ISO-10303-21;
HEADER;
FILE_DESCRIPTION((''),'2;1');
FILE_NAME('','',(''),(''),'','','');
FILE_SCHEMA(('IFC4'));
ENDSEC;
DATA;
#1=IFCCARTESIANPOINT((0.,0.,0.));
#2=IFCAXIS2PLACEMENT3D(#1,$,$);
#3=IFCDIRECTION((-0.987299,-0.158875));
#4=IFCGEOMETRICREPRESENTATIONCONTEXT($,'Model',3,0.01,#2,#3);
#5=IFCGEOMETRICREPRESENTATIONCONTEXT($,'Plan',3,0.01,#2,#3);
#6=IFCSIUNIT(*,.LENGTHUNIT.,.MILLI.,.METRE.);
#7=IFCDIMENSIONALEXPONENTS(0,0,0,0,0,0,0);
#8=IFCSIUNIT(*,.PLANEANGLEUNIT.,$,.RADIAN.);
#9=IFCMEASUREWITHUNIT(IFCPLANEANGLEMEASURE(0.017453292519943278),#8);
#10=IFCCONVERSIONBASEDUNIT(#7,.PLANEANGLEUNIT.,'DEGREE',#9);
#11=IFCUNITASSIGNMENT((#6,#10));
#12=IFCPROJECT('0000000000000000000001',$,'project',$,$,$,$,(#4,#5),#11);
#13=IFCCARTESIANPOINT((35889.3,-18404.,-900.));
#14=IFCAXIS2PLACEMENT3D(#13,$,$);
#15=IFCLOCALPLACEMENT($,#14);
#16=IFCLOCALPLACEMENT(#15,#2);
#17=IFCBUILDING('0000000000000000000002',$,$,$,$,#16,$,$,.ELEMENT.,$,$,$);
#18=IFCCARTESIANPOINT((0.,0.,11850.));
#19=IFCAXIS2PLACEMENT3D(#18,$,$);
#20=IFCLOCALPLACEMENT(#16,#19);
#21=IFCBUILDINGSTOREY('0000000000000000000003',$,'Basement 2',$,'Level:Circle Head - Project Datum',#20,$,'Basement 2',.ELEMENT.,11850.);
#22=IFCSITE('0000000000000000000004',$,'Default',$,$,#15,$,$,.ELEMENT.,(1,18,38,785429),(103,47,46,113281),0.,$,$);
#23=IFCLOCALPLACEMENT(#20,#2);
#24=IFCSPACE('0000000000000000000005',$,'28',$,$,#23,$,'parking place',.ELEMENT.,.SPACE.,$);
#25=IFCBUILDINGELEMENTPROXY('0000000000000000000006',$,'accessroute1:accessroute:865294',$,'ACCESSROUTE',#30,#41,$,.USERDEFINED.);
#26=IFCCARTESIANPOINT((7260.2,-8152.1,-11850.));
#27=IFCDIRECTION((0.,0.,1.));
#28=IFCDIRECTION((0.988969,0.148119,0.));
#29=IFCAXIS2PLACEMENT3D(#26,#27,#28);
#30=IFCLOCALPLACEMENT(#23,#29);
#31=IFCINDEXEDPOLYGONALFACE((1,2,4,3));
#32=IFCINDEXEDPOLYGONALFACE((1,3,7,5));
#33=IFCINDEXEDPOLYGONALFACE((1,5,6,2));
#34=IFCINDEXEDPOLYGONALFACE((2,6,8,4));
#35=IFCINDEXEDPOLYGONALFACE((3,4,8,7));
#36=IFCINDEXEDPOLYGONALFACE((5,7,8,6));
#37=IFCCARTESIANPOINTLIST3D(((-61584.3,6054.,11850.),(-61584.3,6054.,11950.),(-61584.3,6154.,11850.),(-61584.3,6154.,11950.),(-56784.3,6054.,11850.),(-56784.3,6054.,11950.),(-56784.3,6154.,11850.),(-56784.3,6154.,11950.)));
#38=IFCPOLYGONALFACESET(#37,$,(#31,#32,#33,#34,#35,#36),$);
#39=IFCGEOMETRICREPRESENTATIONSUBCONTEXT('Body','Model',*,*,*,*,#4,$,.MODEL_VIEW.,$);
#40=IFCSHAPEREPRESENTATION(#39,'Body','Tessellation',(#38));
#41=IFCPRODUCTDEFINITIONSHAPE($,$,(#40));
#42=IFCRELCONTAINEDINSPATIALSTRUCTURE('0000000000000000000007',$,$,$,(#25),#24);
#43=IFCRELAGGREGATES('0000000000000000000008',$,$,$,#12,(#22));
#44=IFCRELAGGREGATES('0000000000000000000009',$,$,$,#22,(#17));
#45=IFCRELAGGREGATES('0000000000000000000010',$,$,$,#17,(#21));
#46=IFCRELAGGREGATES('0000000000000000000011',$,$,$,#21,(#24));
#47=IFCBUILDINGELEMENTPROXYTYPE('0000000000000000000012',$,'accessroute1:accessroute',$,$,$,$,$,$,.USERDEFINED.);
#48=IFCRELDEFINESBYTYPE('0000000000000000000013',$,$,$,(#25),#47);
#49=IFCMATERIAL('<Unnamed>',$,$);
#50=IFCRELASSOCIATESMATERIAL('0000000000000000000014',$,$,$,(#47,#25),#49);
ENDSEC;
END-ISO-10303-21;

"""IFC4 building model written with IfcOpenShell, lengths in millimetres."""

from ifc_helpers import new_model, entity, si_unit, converted_unit, direction, frame, origin, place, context, subcontext, project, spatial, indexed_curve, outline, extrude, source, transform, mapped, material, type_object, type_shapes, element, save


model = new_model("IFC4")

# Units and contexts
model_context = context("Model", 3, precision=0.01, world=origin(), true_north=direction((-0.987299, -0.158875)))
plan_context = context("Plan", 3, precision=0.01, world=origin(), true_north=direction((-0.987299, -0.158875)))
body_context = subcontext(model_context, "Body", "Model", "MODEL_VIEW")
ifc_project = project(units=[si_unit("LENGTHUNIT", "METRE", prefix="MILLI"), converted_unit("PLANEANGLEUNIT", "DEGREE", entity("IfcPlaneAngleMeasure", 0.017453292519943278), si_unit("PLANEANGLEUNIT", "RADIAN"), dimensions=[0, 0, 0, 0, 0, 0, 0])], contexts=[model_context, plan_context])

# Site, building, storey
site_placement = place(None, frame((35889.3, -18404.0, -900.0)))
site = spatial("IfcSite", under=ifc_project, at=site_placement, Name="Default", CompositionType="ELEMENT", RefLatitude=(1, 18, 38, 785429), RefLongitude=(103, 47, 46, 113281), RefElevation=0.0)
building_placement = place(site_placement, origin())
building = spatial("IfcBuilding", under=site, at=building_placement, CompositionType="ELEMENT")
storey_placement = place(building_placement, frame((0.0, 0.0, 11850.0)))
storey = spatial("IfcBuildingStorey", under=building, at=storey_placement, Name="Basement 2", ObjectType="Level:Circle Head - Project Datum", LongName="Basement 2", CompositionType="ELEMENT", Elevation=11850.0)

# Shared definitions
ifc_material_1 = material(Name="<Unnamed>")

# Shared definitions
space_placement = place(storey_placement, origin())
space = spatial("IfcSpace", under=storey, at=space_placement, Name="28", LongName="parking place", CompositionType="ELEMENT", PredefinedType="SPACE")

# Building element proxy
building_element_proxy_type_1 = type_object("IfcBuildingElementProxyType", Name="accessroute1:accessroute", PredefinedType="USERDEFINED", material=ifc_material_1)
shared_shape_1 = source(origin(), body_context, "Body", "SweptSolid", [
    extrude(outline(indexed_curve([(-2400.0, -50.0), (2400.0, -50.0), (2400.0, 50.0), (-2400.0, 50.0), (-2400.0, -50.0)], self_intersect=False)), frame((-59184.3, 6104.0, 11850.0), z_axis=(0.0, 0.0, 1.0), x_axis=(-1.0, 0.0, 0.0)), (0.0, 0.0, 1.0), 100.0),
])
type_shapes(building_element_proxy_type_1, [shared_shape_1])
proxy_1_placement = place(space_placement, frame((7260.2, -8152.1, -11850.0), z_axis=(0.0, 0.0, 1.0), x_axis=(0.988969, 0.148119, 0.0)))
element("IfcBuildingElementProxy", 1, at=proxy_1_placement, inside=space, type_object=building_element_proxy_type_1, material=ifc_material_1, Name="accessroute1:accessroute:865294", ObjectType="ACCESSROUTE", PredefinedType="USERDEFINED", context=body_context, shape_type="MappedRepresentation", body=[
    mapped(shared_shape_1, transform((0.0, 0.0, 0.0), scale=1.0)),
])

save(model, "model.ifc")
